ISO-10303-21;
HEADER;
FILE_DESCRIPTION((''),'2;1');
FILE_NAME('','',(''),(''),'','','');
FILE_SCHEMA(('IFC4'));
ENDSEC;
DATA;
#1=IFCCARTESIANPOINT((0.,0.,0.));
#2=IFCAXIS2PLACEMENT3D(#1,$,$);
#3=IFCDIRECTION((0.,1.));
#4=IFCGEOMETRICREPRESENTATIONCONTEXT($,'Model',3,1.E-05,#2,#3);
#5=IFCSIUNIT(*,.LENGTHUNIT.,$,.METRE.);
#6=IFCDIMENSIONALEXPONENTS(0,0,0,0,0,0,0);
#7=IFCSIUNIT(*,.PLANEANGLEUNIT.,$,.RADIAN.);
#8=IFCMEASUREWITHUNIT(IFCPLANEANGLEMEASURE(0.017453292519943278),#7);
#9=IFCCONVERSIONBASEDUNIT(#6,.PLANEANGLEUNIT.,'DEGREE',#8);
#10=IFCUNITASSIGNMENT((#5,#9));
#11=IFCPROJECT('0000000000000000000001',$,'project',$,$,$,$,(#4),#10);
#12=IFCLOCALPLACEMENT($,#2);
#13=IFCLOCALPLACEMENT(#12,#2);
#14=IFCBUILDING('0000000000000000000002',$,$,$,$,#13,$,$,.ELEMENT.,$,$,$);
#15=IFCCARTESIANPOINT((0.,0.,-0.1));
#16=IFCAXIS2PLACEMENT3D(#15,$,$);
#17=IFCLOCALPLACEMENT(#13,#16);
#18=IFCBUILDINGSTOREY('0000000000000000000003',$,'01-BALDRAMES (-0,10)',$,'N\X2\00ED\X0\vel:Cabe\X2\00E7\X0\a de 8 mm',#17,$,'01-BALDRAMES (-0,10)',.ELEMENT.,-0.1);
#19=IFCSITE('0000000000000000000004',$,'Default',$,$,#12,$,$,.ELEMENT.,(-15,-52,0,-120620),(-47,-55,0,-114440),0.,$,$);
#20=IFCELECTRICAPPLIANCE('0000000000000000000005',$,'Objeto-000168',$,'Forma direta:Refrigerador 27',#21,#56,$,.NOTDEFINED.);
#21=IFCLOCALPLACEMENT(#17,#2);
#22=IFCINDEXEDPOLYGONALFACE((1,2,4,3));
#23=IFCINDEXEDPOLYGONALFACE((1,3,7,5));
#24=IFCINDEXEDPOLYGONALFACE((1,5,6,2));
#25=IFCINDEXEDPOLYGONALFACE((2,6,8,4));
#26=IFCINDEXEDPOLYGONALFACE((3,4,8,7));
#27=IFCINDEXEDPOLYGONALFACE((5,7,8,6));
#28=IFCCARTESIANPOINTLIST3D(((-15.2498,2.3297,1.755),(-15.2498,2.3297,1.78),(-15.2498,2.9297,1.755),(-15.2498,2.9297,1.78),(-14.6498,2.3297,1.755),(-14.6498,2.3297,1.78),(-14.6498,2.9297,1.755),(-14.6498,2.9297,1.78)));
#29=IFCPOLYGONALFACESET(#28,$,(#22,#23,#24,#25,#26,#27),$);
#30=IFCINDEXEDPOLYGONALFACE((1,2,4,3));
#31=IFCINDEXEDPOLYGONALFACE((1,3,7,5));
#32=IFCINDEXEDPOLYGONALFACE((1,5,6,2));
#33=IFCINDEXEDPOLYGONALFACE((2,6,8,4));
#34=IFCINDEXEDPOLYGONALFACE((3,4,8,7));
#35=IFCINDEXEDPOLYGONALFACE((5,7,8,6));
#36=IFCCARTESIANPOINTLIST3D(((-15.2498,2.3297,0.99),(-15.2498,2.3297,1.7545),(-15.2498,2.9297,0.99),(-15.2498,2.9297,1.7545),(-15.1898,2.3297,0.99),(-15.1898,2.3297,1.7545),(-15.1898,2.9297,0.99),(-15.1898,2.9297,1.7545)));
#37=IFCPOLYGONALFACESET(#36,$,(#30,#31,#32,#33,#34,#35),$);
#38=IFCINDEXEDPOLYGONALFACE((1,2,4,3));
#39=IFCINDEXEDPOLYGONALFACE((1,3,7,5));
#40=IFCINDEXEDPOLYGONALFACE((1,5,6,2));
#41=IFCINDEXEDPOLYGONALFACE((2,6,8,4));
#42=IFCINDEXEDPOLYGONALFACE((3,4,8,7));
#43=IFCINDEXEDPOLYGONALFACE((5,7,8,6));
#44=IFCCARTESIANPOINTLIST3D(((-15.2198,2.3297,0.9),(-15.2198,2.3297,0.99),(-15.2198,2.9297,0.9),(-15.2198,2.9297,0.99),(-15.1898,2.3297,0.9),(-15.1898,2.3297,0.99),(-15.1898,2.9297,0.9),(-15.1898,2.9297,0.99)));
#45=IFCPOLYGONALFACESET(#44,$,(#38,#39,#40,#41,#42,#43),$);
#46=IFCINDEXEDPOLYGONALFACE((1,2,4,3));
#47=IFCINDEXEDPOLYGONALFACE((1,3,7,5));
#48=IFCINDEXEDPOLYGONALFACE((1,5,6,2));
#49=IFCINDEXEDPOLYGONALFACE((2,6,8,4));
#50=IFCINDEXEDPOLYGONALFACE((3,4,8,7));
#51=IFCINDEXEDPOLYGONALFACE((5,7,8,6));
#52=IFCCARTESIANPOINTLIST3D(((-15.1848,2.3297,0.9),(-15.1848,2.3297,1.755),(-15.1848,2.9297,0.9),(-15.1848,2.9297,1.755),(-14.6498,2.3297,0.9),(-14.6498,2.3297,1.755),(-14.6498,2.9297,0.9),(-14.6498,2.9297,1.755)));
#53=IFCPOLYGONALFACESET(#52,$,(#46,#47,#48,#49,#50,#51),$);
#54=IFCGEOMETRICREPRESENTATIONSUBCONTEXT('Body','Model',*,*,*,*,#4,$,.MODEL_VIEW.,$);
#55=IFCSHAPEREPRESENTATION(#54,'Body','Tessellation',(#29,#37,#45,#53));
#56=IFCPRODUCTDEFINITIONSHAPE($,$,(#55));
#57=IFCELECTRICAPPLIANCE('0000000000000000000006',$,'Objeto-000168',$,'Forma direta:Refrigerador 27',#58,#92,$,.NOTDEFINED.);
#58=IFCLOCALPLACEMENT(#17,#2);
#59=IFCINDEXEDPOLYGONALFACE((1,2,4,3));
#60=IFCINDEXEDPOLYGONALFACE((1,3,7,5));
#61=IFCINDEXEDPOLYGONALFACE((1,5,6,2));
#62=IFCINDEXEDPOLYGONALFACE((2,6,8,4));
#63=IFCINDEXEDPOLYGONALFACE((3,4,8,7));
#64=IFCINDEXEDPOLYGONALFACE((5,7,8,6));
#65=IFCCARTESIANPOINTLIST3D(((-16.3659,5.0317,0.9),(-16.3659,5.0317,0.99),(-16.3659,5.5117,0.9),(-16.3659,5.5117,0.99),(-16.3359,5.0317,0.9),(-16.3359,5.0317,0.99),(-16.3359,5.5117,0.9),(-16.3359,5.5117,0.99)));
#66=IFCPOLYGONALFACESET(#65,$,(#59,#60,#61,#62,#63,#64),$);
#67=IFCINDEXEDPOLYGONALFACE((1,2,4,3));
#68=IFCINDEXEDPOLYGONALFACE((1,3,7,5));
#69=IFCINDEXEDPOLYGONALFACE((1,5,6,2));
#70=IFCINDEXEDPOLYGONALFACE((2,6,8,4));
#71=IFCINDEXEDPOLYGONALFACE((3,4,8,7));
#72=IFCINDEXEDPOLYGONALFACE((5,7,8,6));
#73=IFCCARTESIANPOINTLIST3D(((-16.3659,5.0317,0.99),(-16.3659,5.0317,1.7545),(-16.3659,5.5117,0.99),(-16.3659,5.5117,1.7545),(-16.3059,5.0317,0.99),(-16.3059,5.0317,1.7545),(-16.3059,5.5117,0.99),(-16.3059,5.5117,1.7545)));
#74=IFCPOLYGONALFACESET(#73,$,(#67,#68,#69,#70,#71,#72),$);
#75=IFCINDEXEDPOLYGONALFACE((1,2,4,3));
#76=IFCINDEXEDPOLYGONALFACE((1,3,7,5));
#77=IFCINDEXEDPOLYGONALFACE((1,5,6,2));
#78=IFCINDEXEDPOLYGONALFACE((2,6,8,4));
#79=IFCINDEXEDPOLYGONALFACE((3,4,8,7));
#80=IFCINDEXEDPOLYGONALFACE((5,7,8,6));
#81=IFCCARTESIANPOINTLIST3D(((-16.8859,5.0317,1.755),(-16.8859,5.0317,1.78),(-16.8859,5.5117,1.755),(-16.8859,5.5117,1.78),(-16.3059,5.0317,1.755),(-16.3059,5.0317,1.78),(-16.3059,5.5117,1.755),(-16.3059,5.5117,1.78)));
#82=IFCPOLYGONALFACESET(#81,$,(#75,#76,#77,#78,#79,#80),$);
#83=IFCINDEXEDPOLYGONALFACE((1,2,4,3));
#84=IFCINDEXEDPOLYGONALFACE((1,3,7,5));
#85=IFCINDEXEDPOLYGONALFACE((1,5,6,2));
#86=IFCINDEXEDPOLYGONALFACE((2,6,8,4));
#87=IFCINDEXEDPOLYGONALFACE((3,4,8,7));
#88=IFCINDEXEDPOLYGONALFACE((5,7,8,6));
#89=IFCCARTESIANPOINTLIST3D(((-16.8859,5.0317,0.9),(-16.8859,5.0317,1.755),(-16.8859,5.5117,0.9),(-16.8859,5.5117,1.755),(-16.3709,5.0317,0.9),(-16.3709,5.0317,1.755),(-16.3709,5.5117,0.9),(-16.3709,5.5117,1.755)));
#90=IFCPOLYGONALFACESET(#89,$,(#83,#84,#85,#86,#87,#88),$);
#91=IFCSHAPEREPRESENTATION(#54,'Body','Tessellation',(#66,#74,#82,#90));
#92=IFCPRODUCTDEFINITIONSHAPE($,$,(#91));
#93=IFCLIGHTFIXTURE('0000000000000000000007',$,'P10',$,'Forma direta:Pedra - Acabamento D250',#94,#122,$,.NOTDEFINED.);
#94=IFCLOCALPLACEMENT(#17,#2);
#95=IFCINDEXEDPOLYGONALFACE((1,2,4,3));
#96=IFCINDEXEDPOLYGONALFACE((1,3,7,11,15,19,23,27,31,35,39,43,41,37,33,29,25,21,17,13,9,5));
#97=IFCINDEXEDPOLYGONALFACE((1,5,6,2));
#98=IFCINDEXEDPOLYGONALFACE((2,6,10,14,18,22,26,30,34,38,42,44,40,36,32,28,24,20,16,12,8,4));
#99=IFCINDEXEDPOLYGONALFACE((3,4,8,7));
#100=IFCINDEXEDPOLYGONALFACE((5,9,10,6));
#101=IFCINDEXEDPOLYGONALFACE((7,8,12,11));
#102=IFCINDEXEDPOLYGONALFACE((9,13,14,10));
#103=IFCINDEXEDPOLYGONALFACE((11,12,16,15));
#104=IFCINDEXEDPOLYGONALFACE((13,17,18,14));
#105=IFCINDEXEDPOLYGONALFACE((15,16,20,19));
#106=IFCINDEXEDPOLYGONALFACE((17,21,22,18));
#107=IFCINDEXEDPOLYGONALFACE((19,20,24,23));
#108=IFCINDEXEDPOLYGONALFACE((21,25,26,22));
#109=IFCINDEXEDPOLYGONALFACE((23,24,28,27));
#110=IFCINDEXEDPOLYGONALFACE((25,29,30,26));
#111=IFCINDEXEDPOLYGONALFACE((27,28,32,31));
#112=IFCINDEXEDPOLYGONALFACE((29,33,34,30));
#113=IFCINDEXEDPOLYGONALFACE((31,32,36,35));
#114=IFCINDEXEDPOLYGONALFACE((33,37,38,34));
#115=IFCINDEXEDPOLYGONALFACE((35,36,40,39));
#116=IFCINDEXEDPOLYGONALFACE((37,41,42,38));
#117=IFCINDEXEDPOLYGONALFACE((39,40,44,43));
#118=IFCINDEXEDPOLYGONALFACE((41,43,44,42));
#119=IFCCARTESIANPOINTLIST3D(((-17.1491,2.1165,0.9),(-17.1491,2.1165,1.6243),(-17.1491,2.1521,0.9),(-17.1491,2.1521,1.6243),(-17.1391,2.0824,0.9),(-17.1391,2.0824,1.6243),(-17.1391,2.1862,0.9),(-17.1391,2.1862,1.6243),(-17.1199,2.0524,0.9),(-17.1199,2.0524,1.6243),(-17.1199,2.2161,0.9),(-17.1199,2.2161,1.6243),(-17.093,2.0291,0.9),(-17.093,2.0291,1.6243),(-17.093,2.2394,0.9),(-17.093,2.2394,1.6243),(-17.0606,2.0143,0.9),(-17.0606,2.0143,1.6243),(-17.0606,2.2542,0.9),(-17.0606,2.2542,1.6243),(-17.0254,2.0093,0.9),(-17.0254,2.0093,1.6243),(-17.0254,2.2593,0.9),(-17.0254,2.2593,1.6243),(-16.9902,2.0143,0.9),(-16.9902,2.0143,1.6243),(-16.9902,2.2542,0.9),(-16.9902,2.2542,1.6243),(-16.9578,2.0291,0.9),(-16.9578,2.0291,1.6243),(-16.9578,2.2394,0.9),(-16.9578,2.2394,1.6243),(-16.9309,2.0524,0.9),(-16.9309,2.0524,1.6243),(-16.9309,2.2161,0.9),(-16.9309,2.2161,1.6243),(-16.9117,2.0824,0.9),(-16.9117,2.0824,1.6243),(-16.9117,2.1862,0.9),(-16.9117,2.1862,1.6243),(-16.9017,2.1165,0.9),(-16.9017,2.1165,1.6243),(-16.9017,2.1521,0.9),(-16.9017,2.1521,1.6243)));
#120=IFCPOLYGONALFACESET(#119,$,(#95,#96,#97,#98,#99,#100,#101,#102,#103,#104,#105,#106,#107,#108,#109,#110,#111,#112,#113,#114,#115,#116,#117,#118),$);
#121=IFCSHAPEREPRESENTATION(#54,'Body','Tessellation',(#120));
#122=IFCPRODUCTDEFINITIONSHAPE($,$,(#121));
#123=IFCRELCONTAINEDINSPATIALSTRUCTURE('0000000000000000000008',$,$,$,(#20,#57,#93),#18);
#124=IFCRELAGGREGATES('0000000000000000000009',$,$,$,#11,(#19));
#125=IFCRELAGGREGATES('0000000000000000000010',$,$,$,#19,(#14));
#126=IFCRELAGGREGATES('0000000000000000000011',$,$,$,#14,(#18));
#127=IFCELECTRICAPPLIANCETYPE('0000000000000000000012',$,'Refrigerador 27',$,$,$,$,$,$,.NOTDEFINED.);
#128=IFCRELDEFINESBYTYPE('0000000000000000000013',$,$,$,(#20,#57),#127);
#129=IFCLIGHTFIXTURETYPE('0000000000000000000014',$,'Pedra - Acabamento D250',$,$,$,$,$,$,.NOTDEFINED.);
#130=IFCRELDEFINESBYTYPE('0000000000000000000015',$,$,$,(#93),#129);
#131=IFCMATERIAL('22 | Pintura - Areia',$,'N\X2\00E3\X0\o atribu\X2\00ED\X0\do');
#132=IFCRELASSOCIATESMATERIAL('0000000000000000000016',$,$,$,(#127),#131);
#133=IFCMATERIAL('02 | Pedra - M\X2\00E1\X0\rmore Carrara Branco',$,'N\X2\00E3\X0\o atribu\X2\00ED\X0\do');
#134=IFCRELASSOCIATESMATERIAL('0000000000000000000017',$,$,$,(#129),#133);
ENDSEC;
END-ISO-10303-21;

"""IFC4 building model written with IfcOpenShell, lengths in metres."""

from ifc_helpers import new_model, entity, si_unit, converted_unit, direction, frame, origin, place, context, subcontext, project, spatial, arc, indexed_curve, outline, extrude, material, type_object, element, save


model = new_model("IFC4")

# Units and contexts
model_context = context("Model", 3, precision=1e-05, world=origin(), true_north=direction((0.0, 1.0)))
body_context = subcontext(model_context, "Body", "Model", "MODEL_VIEW")
ifc_project = project(units=[si_unit("LENGTHUNIT", "METRE"), converted_unit("PLANEANGLEUNIT", "DEGREE", entity("IfcPlaneAngleMeasure", 0.017453292519943278), si_unit("PLANEANGLEUNIT", "RADIAN"), dimensions=[0, 0, 0, 0, 0, 0, 0])], contexts=[model_context])

# Site, building, storey
site_placement = place(None, origin())
site = spatial("IfcSite", under=ifc_project, at=site_placement, Name="Default", CompositionType="ELEMENT", RefLatitude=(-15, -52, 0, -120620), RefLongitude=(-47, -55, 0, -114440), RefElevation=0.0)
building_placement = place(site_placement, origin())
building = spatial("IfcBuilding", under=site, at=building_placement, CompositionType="ELEMENT")
storey_placement = place(building_placement, frame((0.0, 0.0, -0.1)))
storey = spatial("IfcBuildingStorey", under=building, at=storey_placement, Name="01-BALDRAMES (-0,10)", ObjectType="Nível:Cabeça de 8 mm", LongName="01-BALDRAMES (-0,10)", CompositionType="ELEMENT", Elevation=-0.1)

# Shared definitions
ifc_material_1 = material(Name="22 | Pintura - Areia", Category="Não atribuído")

# Electric appliances
electric_appliance_type_1 = type_object("IfcElectricApplianceType", Name="Refrigerador 27", PredefinedType="NOTDEFINED", material=ifc_material_1)
electric_appliance_1_placement = place(storey_placement, origin())
element("IfcElectricAppliance", 1, at=electric_appliance_1_placement, inside=storey, type_object=electric_appliance_type_1, Name="Objeto-000168", ObjectType="Forma direta:Refrigerador 27", PredefinedType="NOTDEFINED", context=body_context, shape_type="SweptSolid", body=[
    extrude(outline(indexed_curve([(-0.3, -0.3), (0.3, -0.3), (0.3, 0.3), (-0.3, 0.3), (-0.3, -0.3)], self_intersect=False)), frame((-14.9498, 2.6297, 1.755), z_axis=(0.0, 0.0, 1.0), x_axis=(-0.000013, -1.0, 0.0)), (0.0, 0.0, 1.0), 0.025),
    extrude(outline(indexed_curve([(-0.03, -0.3), (0.03, -0.3), (0.03, 0.3), (-0.03, 0.3), (-0.03, -0.3)], self_intersect=False)), frame((-15.2198, 2.6297, 0.99), z_axis=(0.0, 0.0, 1.0), x_axis=(-1.0, 0.000013, 0.0)), (0.0, 0.0, 1.0), 0.7645),
    extrude(outline(indexed_curve([(-0.3, -0.015), (0.3, -0.015), (0.3, 0.015), (-0.3, 0.015), (-0.3, -0.015)], self_intersect=False)), frame((-15.2048, 2.6297, 0.9), z_axis=(0.0, 0.0, 1.0), x_axis=(-0.000013, -1.0, 0.0)), (0.0, 0.0, 1.0), 0.09),
    extrude(outline(indexed_curve([(-0.3, -0.2675), (0.3, -0.2675), (0.3, 0.2675), (-0.3, 0.2675), (-0.3, -0.2675)], self_intersect=False)), frame((-14.9173, 2.6297, 0.9), z_axis=(0.0, 0.0, 1.0), x_axis=(-0.000013, -1.0, 0.0)), (0.0, 0.0, 1.0), 0.855),
])
electric_appliance_2_placement = place(storey_placement, origin())
element("IfcElectricAppliance", 2, at=electric_appliance_2_placement, inside=storey, type_object=electric_appliance_type_1, Name="Objeto-000168", ObjectType="Forma direta:Refrigerador 27", PredefinedType="NOTDEFINED", context=body_context, shape_type="SweptSolid", body=[
    extrude(outline(indexed_curve([(-0.24, -0.015), (0.24, -0.015), (0.24, 0.015), (-0.24, 0.015), (-0.24, -0.015)], self_intersect=False)), frame((-16.3509, 5.2717, 0.9), z_axis=(0.0, 0.0, 1.0), x_axis=(0.000013, 1.0, 0.0)), (0.0, 0.0, 1.0), 0.09),
    extrude(outline(indexed_curve([(-0.03, -0.24), (0.03, -0.24), (0.03, 0.24), (-0.03, 0.24), (-0.03, -0.24)], self_intersect=False)), frame((-16.3359, 5.2717, 0.99)), (0.0, 0.0, 1.0), 0.7645),
    extrude(outline(indexed_curve([(-0.24, -0.29), (0.24, -0.29), (0.24, 0.29), (-0.24, 0.29), (-0.24, -0.29)], self_intersect=False)), frame((-16.5959, 5.2717, 1.755), z_axis=(0.0, 0.0, 1.0), x_axis=(0.000013, 1.0, 0.0)), (0.0, 0.0, 1.0), 0.025),
    extrude(outline(indexed_curve([(-0.24, -0.2575), (0.24, -0.2575), (0.24, 0.2575), (-0.24, 0.2575), (-0.24, -0.2575)], self_intersect=False)), frame((-16.6284, 5.2717, 0.9), z_axis=(0.0, 0.0, 1.0), x_axis=(0.000013, 1.0, 0.0)), (0.0, 0.0, 1.0), 0.855),
])

# Light fixture
ifc_material_2 = material(Name="02 | Pedra - Mármore Carrara Branco", Category="Não atribuído")
light_fixture_type_1 = type_object("IfcLightFixtureType", Name="Pedra - Acabamento D250", PredefinedType="NOTDEFINED", material=ifc_material_2)
light_fixture_1_placement = place(storey_placement, origin())
element("IfcLightFixture", 3, at=light_fixture_1_placement, inside=storey, type_object=light_fixture_type_1, Name="P10", ObjectType="Forma direta:Pedra - Acabamento D250", PredefinedType="NOTDEFINED", context=body_context, shape_type="SweptSolid", body=[
    extrude(outline(indexed_curve([(0.125, 0.0), (0.0, 0.125), (-0.125, 0.0), (0.0, -0.125)], segments=[arc(1, 2, 3), arc(3, 4, 1)], self_intersect=False)), frame((-17.0254, 2.1343, 0.9), z_axis=(0.0, 0.0, 1.0), x_axis=(-0.000013, -1.0, 0.0)), (0.0, 0.0, 1.0), 0.7243),
])

save(model, "model.ifc")
